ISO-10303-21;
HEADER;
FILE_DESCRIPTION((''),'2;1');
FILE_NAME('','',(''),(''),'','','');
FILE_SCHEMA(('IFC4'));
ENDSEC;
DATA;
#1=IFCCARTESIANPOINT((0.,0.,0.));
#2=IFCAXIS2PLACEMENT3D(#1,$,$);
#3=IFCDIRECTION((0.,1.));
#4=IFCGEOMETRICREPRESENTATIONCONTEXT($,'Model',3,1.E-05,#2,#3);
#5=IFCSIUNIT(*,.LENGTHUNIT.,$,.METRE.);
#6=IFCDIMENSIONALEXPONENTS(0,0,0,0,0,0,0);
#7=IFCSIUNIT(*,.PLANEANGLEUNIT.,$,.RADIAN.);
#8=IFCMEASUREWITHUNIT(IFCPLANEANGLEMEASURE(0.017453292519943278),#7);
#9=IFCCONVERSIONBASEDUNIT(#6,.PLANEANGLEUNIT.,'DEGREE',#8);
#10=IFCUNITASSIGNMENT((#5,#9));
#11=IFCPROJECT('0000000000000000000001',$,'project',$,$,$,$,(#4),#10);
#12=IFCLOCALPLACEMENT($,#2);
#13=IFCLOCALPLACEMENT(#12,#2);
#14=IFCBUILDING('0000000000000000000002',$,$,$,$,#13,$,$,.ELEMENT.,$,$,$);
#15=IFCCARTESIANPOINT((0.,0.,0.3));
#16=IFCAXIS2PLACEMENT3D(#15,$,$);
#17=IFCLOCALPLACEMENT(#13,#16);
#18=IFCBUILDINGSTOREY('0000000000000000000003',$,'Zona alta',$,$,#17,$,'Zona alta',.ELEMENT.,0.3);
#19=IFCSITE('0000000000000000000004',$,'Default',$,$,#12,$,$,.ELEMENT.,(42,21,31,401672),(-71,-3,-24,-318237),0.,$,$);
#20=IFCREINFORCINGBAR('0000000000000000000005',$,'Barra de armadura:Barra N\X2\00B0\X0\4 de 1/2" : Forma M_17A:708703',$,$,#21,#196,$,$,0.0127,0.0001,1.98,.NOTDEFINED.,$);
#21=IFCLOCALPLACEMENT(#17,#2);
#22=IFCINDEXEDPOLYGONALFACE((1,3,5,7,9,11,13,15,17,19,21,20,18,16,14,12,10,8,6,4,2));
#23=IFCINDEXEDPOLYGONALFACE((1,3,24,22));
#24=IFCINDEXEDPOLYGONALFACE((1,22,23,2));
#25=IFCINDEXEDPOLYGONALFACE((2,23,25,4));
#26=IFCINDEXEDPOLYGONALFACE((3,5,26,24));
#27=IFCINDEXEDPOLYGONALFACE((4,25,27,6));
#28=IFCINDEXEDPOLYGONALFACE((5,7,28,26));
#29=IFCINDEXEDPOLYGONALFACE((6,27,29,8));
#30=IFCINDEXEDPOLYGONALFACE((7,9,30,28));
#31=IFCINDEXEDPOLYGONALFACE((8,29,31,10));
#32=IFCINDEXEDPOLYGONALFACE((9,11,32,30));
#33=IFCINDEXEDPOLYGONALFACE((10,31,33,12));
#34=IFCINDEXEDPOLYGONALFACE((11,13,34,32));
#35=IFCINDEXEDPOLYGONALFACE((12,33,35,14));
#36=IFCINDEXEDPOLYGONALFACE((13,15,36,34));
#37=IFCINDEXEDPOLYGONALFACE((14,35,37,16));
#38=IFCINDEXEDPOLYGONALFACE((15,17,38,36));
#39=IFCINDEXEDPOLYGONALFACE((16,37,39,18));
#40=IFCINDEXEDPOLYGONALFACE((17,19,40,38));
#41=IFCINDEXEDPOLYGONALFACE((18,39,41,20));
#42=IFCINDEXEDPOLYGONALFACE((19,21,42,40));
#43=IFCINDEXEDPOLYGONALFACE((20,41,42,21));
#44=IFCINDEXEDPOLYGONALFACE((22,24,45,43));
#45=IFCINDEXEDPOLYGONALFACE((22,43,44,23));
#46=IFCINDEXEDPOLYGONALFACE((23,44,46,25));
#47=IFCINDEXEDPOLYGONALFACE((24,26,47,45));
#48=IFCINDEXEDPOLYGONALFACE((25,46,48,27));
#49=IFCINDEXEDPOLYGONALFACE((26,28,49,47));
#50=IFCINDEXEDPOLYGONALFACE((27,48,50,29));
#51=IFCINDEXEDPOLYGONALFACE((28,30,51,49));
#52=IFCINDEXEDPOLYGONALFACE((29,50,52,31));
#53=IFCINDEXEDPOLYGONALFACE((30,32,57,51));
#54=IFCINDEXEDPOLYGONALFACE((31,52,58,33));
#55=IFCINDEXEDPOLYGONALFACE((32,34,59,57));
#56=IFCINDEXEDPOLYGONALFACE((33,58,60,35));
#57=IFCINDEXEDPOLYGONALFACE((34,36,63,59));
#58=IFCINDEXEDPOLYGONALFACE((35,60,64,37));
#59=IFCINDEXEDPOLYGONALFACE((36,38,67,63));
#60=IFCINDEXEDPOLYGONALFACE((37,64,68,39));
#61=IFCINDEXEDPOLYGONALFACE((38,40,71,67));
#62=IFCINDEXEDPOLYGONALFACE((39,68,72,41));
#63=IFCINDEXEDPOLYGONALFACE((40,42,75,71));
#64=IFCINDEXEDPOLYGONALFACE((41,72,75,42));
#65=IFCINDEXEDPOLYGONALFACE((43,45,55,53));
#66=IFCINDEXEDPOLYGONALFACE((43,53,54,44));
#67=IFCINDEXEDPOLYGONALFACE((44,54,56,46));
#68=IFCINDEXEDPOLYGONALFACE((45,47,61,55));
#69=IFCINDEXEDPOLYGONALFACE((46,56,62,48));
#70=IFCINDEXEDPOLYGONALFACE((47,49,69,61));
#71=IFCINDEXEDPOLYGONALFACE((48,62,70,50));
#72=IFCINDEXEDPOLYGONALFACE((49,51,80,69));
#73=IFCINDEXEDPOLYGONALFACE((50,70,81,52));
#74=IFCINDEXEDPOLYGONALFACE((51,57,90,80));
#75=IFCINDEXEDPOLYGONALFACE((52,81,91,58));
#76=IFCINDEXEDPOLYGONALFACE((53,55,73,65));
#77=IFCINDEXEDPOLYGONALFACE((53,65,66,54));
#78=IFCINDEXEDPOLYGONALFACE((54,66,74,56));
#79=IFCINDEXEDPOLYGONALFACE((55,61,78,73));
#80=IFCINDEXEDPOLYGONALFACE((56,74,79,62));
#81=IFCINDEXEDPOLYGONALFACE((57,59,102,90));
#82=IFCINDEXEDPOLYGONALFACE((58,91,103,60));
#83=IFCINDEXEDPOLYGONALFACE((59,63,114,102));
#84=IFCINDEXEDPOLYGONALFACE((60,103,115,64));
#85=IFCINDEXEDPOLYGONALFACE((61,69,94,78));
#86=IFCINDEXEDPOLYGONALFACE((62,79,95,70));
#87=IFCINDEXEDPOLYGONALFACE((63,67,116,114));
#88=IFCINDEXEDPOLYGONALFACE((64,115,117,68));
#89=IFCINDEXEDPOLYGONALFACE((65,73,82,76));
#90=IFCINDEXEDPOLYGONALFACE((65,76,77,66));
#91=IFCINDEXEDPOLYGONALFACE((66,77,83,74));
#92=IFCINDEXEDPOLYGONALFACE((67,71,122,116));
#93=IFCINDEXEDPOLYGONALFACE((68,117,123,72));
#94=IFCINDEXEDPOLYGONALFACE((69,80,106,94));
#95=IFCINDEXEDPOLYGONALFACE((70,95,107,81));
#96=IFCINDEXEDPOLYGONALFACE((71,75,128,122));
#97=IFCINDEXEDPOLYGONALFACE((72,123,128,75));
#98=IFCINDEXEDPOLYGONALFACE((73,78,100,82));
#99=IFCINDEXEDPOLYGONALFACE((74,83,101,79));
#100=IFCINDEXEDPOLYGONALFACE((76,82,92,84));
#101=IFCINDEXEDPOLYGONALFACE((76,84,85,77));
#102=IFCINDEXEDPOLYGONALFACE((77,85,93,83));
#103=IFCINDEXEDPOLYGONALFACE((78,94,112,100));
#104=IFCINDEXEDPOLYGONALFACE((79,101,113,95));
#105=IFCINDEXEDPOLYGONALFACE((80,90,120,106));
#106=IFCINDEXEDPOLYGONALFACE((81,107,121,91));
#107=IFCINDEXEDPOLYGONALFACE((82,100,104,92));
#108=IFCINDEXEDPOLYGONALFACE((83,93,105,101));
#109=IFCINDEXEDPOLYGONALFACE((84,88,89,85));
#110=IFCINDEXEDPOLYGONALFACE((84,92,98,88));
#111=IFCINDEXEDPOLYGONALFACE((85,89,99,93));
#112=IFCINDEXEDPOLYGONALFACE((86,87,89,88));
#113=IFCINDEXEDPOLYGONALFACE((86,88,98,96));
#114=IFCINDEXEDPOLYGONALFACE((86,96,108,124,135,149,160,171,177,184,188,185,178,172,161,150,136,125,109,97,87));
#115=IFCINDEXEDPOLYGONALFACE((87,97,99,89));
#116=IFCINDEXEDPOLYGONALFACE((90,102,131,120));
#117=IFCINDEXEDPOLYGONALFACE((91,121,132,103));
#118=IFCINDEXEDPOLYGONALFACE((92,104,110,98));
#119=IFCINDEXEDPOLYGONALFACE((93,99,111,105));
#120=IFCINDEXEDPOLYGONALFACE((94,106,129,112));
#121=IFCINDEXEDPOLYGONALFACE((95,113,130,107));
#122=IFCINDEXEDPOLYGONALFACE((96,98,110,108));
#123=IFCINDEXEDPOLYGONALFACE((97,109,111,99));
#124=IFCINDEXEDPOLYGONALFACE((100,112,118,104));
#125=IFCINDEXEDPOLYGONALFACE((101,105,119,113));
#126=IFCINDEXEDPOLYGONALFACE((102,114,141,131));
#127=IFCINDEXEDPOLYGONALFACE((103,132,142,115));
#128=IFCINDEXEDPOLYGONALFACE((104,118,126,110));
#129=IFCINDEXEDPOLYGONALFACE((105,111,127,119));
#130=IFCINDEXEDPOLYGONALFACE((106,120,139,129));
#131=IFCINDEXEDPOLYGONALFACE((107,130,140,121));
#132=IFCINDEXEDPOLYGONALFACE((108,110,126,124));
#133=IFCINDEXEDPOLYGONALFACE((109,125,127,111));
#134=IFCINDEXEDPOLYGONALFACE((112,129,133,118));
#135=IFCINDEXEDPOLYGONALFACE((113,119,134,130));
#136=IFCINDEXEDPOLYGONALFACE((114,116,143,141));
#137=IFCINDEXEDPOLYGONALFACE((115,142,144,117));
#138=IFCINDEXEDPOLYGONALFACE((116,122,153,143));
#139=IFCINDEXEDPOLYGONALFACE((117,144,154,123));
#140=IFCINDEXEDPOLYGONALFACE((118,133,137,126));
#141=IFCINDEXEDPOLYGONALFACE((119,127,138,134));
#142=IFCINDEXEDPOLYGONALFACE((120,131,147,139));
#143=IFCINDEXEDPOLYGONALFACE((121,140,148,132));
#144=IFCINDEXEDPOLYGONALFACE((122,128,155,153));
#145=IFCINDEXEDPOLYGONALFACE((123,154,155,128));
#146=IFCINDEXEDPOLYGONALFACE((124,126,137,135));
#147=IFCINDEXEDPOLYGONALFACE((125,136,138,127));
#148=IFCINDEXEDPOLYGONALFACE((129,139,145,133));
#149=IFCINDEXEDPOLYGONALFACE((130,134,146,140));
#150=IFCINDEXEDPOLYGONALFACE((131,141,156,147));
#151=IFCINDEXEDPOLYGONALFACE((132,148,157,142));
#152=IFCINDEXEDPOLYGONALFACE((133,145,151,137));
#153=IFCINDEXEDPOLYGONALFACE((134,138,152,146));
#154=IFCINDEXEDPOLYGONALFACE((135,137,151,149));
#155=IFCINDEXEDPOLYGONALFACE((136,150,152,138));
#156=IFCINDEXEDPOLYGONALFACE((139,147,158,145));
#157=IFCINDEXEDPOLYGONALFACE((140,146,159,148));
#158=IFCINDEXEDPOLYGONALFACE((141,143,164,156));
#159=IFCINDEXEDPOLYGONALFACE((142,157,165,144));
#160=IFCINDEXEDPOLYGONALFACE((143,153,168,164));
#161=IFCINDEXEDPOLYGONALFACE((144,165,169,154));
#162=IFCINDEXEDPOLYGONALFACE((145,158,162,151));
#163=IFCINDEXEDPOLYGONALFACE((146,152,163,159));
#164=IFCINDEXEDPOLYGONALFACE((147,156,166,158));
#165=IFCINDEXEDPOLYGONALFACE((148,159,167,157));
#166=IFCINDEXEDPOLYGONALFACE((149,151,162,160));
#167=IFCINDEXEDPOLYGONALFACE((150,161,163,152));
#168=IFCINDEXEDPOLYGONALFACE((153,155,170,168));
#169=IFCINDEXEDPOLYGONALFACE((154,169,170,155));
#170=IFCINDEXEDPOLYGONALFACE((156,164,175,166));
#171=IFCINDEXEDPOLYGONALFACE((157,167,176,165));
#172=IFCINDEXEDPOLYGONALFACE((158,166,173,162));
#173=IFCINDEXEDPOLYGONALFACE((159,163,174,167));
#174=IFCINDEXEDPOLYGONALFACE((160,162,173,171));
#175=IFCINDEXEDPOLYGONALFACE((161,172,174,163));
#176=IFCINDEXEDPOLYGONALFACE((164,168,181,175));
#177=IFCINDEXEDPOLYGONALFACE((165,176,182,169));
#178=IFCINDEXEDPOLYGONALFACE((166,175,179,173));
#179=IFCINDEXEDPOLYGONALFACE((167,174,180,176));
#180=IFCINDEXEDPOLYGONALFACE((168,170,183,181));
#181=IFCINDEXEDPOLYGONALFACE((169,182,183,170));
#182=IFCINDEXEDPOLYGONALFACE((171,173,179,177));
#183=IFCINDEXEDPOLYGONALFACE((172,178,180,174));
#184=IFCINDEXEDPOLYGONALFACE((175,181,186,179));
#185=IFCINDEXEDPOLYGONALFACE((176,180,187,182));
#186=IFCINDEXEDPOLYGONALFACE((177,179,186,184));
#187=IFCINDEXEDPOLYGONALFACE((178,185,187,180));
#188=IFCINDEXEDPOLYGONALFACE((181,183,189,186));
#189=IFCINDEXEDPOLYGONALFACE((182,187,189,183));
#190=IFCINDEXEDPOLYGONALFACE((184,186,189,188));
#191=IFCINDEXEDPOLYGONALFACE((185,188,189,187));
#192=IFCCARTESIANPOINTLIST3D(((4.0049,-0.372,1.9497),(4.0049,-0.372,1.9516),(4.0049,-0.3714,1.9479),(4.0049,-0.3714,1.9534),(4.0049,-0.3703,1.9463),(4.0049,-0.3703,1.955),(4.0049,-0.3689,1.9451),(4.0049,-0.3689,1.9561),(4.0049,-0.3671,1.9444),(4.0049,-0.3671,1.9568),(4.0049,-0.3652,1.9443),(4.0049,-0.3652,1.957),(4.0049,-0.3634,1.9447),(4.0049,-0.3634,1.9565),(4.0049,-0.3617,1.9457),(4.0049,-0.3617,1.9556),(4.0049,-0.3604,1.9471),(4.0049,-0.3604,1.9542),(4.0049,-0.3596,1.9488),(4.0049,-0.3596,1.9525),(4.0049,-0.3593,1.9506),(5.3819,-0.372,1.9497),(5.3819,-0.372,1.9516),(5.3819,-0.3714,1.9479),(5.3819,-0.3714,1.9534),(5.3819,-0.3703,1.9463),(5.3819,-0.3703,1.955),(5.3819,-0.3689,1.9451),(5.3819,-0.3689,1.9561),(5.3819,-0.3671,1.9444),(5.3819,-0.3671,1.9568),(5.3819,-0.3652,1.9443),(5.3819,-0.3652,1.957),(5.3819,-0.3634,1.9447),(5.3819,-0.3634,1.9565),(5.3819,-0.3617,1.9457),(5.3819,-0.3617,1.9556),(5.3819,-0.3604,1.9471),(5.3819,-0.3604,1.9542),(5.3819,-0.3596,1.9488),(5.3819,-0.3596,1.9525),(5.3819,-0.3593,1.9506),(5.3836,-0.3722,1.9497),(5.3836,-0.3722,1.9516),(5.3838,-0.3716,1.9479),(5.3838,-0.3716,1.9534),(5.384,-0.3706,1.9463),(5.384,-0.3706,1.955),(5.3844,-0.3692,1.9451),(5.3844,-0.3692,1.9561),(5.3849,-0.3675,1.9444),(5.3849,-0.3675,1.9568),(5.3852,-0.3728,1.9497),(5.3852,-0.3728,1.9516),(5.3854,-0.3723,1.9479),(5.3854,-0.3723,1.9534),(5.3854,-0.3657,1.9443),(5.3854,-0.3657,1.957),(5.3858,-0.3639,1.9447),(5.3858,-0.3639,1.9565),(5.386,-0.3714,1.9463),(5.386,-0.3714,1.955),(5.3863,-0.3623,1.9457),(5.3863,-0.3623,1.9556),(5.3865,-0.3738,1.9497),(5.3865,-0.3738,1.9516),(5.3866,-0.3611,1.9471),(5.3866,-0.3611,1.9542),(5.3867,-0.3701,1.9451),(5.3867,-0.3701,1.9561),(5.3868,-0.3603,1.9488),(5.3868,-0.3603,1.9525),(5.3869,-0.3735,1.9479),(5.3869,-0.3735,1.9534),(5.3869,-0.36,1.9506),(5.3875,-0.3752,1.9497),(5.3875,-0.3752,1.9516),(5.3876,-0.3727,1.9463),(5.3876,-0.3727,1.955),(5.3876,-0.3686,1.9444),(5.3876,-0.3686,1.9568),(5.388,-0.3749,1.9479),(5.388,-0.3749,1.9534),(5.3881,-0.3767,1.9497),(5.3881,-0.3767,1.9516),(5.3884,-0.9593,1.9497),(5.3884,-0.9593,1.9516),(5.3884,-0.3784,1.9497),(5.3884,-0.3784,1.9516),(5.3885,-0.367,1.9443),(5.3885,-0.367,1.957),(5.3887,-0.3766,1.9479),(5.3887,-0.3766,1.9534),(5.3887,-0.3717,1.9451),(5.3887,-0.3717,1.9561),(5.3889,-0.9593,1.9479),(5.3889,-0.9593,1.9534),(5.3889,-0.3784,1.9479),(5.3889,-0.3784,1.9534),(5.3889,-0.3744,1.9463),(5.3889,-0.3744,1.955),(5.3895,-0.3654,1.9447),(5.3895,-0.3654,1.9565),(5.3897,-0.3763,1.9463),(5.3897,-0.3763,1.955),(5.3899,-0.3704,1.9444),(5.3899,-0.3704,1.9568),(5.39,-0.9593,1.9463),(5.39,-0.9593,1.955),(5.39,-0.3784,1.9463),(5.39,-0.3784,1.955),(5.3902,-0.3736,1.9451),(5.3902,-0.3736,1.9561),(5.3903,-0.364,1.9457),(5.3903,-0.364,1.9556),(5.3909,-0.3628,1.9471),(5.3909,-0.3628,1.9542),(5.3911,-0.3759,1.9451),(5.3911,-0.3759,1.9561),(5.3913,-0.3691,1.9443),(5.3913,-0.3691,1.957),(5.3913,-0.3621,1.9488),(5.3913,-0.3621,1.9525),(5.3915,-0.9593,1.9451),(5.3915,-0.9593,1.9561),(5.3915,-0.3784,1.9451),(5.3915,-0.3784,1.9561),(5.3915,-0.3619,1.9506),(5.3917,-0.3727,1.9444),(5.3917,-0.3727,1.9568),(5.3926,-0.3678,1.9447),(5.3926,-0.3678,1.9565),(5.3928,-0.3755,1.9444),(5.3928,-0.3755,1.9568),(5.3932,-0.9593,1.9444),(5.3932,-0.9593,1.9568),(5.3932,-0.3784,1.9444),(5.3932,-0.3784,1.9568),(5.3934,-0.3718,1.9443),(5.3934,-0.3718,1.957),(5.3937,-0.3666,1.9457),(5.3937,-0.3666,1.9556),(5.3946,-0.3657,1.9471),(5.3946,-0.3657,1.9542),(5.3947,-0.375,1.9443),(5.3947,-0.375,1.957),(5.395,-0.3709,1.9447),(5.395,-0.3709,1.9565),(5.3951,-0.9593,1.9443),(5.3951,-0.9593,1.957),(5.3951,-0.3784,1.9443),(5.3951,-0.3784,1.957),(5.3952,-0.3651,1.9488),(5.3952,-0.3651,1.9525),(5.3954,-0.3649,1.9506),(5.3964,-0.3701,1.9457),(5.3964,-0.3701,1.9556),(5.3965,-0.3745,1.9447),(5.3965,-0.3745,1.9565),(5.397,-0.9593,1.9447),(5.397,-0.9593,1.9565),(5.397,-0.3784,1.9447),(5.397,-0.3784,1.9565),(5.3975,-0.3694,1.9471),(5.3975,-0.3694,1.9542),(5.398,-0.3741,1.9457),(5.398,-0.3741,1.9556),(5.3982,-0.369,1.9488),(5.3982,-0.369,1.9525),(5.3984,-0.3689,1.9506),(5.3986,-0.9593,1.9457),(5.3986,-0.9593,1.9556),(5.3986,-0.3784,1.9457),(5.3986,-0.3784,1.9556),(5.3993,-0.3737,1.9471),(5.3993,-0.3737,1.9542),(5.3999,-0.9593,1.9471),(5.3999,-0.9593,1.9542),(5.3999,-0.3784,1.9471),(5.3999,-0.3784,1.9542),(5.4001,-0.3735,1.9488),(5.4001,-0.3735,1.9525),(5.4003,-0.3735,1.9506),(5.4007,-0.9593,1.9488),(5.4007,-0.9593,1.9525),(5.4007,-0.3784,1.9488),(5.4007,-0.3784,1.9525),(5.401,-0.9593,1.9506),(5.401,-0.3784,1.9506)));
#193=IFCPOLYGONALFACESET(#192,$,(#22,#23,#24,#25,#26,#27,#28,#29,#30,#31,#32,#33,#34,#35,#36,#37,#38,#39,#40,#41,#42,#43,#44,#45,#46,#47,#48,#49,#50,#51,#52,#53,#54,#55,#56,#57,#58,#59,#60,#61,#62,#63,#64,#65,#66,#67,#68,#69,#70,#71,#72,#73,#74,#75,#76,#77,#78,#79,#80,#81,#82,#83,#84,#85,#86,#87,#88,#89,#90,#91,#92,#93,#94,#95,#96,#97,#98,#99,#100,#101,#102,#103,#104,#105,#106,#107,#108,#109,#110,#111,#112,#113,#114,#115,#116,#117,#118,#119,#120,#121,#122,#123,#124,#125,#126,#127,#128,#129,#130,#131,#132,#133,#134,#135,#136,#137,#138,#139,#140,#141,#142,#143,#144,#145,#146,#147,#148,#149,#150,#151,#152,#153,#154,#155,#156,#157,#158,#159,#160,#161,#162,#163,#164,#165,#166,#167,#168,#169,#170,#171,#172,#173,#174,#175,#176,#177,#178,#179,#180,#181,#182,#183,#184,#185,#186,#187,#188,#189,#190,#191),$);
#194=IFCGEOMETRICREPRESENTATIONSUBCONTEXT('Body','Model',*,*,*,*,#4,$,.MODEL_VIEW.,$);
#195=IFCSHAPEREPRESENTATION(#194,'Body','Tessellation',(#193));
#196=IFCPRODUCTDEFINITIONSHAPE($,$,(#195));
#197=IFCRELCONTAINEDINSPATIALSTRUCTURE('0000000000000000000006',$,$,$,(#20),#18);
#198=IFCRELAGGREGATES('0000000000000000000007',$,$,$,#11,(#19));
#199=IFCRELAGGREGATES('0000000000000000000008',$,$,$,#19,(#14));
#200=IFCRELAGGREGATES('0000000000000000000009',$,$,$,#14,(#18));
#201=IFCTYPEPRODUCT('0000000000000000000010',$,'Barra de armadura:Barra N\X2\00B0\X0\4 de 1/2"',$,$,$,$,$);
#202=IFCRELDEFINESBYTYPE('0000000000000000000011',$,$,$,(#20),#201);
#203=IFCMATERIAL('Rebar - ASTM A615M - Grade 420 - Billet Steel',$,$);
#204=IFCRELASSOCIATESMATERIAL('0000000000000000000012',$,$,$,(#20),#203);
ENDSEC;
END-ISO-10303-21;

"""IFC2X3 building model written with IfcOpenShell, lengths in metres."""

from ifc_helpers import new_model, entity, si_unit, converted_unit, direction, frame, origin, place, context, subcontext, project, spatial, material, type_object, element, save


model = new_model("IFC2X3")

# Units and contexts
model_context = context("Model", 3, precision=1e-05, world=origin(), true_north=direction((0.0, 1.0)))
body_context = subcontext(model_context, "Body", "Model", "MODEL_VIEW")
ifc_project = project(units=[si_unit("LENGTHUNIT", "METRE"), converted_unit("PLANEANGLEUNIT", "DEGREE", entity("IfcPlaneAngleMeasure", 0.017453292519943278), si_unit("PLANEANGLEUNIT", "RADIAN"), dimensions=[0, 0, 0, 0, 0, 0, 0])], contexts=[model_context])

# Site, building, storey
site_placement = place(None, origin())
site = spatial("IfcSite", under=ifc_project, at=site_placement, Name="Default", CompositionType="ELEMENT", RefLatitude=(42, 21, 31, 401672), RefLongitude=(-71, -3, -24, -318237), RefElevation=0.0)
building_placement = place(site_placement, origin())
building = spatial("IfcBuilding", under=site, at=building_placement, CompositionType="ELEMENT")
storey_placement = place(building_placement, frame((0.0, 0.0, 0.3)))
storey = spatial("IfcBuildingStorey", under=building, at=storey_placement, Name="Zona alta", LongName="Zona alta", CompositionType="ELEMENT", Elevation=0.3)

# Reinforcing bar
ifc_material = material(Name="Rebar - ASTM A615M - Grade 420 - Billet Steel")
type_product_1 = type_object("IfcTypeProduct", Name="Barra de armadura:Barra N°4 de 1/2\"")
reinforcing_bar_1_placement = place(storey_placement, origin())
element("IfcReinforcingBar", 1, at=reinforcing_bar_1_placement, inside=storey, type_object=type_product_1, material=ifc_material, Name="Barra de armadura:Barra N°4 de 1/2\" : Forma M_17A:708703", BarLength=1.98, BarRole="NOTDEFINED", CrossSectionArea=0.0001, NominalDiameter=0.0127, context=body_context, shape_type="AdvancedSweptSolid", body=[
    entity("IfcSweptDiskSolid", entity("IfcCompositeCurve", [entity("IfcCompositeCurveSegment", "CONTINUOUS", True, entity("IfcPolyline", [entity("IfcCartesianPoint", [4.0049, -0.3657, 1.9506]), entity("IfcCartesianPoint", [5.3819, -0.3657, 1.9506])])), entity("IfcCompositeCurveSegment", "CONTINUOUS", True, entity("IfcTrimmedCurve", entity("IfcCircle", entity("IfcAxis2Placement3D", entity("IfcCartesianPoint", [5.3819, -0.3784, 1.9506]), entity("IfcDirection", [0.0, 0.0, -1.0]), entity("IfcDirection", [1.0, 0.0, 0.0])), 0.0127), [entity("IfcParameterValue", 270.0)], [entity("IfcParameterValue", 360.0)], True, "PARAMETER")), entity("IfcCompositeCurveSegment", "CONTINUOUS", True, entity("IfcPolyline", [entity("IfcCartesianPoint", [5.3946, -0.3784, 1.9506]), entity("IfcCartesianPoint", [5.3946, -0.9593, 1.9506])]))], False), 0.0063, None, 0.0, 92.0),
])

save(model, "model.ifc")
